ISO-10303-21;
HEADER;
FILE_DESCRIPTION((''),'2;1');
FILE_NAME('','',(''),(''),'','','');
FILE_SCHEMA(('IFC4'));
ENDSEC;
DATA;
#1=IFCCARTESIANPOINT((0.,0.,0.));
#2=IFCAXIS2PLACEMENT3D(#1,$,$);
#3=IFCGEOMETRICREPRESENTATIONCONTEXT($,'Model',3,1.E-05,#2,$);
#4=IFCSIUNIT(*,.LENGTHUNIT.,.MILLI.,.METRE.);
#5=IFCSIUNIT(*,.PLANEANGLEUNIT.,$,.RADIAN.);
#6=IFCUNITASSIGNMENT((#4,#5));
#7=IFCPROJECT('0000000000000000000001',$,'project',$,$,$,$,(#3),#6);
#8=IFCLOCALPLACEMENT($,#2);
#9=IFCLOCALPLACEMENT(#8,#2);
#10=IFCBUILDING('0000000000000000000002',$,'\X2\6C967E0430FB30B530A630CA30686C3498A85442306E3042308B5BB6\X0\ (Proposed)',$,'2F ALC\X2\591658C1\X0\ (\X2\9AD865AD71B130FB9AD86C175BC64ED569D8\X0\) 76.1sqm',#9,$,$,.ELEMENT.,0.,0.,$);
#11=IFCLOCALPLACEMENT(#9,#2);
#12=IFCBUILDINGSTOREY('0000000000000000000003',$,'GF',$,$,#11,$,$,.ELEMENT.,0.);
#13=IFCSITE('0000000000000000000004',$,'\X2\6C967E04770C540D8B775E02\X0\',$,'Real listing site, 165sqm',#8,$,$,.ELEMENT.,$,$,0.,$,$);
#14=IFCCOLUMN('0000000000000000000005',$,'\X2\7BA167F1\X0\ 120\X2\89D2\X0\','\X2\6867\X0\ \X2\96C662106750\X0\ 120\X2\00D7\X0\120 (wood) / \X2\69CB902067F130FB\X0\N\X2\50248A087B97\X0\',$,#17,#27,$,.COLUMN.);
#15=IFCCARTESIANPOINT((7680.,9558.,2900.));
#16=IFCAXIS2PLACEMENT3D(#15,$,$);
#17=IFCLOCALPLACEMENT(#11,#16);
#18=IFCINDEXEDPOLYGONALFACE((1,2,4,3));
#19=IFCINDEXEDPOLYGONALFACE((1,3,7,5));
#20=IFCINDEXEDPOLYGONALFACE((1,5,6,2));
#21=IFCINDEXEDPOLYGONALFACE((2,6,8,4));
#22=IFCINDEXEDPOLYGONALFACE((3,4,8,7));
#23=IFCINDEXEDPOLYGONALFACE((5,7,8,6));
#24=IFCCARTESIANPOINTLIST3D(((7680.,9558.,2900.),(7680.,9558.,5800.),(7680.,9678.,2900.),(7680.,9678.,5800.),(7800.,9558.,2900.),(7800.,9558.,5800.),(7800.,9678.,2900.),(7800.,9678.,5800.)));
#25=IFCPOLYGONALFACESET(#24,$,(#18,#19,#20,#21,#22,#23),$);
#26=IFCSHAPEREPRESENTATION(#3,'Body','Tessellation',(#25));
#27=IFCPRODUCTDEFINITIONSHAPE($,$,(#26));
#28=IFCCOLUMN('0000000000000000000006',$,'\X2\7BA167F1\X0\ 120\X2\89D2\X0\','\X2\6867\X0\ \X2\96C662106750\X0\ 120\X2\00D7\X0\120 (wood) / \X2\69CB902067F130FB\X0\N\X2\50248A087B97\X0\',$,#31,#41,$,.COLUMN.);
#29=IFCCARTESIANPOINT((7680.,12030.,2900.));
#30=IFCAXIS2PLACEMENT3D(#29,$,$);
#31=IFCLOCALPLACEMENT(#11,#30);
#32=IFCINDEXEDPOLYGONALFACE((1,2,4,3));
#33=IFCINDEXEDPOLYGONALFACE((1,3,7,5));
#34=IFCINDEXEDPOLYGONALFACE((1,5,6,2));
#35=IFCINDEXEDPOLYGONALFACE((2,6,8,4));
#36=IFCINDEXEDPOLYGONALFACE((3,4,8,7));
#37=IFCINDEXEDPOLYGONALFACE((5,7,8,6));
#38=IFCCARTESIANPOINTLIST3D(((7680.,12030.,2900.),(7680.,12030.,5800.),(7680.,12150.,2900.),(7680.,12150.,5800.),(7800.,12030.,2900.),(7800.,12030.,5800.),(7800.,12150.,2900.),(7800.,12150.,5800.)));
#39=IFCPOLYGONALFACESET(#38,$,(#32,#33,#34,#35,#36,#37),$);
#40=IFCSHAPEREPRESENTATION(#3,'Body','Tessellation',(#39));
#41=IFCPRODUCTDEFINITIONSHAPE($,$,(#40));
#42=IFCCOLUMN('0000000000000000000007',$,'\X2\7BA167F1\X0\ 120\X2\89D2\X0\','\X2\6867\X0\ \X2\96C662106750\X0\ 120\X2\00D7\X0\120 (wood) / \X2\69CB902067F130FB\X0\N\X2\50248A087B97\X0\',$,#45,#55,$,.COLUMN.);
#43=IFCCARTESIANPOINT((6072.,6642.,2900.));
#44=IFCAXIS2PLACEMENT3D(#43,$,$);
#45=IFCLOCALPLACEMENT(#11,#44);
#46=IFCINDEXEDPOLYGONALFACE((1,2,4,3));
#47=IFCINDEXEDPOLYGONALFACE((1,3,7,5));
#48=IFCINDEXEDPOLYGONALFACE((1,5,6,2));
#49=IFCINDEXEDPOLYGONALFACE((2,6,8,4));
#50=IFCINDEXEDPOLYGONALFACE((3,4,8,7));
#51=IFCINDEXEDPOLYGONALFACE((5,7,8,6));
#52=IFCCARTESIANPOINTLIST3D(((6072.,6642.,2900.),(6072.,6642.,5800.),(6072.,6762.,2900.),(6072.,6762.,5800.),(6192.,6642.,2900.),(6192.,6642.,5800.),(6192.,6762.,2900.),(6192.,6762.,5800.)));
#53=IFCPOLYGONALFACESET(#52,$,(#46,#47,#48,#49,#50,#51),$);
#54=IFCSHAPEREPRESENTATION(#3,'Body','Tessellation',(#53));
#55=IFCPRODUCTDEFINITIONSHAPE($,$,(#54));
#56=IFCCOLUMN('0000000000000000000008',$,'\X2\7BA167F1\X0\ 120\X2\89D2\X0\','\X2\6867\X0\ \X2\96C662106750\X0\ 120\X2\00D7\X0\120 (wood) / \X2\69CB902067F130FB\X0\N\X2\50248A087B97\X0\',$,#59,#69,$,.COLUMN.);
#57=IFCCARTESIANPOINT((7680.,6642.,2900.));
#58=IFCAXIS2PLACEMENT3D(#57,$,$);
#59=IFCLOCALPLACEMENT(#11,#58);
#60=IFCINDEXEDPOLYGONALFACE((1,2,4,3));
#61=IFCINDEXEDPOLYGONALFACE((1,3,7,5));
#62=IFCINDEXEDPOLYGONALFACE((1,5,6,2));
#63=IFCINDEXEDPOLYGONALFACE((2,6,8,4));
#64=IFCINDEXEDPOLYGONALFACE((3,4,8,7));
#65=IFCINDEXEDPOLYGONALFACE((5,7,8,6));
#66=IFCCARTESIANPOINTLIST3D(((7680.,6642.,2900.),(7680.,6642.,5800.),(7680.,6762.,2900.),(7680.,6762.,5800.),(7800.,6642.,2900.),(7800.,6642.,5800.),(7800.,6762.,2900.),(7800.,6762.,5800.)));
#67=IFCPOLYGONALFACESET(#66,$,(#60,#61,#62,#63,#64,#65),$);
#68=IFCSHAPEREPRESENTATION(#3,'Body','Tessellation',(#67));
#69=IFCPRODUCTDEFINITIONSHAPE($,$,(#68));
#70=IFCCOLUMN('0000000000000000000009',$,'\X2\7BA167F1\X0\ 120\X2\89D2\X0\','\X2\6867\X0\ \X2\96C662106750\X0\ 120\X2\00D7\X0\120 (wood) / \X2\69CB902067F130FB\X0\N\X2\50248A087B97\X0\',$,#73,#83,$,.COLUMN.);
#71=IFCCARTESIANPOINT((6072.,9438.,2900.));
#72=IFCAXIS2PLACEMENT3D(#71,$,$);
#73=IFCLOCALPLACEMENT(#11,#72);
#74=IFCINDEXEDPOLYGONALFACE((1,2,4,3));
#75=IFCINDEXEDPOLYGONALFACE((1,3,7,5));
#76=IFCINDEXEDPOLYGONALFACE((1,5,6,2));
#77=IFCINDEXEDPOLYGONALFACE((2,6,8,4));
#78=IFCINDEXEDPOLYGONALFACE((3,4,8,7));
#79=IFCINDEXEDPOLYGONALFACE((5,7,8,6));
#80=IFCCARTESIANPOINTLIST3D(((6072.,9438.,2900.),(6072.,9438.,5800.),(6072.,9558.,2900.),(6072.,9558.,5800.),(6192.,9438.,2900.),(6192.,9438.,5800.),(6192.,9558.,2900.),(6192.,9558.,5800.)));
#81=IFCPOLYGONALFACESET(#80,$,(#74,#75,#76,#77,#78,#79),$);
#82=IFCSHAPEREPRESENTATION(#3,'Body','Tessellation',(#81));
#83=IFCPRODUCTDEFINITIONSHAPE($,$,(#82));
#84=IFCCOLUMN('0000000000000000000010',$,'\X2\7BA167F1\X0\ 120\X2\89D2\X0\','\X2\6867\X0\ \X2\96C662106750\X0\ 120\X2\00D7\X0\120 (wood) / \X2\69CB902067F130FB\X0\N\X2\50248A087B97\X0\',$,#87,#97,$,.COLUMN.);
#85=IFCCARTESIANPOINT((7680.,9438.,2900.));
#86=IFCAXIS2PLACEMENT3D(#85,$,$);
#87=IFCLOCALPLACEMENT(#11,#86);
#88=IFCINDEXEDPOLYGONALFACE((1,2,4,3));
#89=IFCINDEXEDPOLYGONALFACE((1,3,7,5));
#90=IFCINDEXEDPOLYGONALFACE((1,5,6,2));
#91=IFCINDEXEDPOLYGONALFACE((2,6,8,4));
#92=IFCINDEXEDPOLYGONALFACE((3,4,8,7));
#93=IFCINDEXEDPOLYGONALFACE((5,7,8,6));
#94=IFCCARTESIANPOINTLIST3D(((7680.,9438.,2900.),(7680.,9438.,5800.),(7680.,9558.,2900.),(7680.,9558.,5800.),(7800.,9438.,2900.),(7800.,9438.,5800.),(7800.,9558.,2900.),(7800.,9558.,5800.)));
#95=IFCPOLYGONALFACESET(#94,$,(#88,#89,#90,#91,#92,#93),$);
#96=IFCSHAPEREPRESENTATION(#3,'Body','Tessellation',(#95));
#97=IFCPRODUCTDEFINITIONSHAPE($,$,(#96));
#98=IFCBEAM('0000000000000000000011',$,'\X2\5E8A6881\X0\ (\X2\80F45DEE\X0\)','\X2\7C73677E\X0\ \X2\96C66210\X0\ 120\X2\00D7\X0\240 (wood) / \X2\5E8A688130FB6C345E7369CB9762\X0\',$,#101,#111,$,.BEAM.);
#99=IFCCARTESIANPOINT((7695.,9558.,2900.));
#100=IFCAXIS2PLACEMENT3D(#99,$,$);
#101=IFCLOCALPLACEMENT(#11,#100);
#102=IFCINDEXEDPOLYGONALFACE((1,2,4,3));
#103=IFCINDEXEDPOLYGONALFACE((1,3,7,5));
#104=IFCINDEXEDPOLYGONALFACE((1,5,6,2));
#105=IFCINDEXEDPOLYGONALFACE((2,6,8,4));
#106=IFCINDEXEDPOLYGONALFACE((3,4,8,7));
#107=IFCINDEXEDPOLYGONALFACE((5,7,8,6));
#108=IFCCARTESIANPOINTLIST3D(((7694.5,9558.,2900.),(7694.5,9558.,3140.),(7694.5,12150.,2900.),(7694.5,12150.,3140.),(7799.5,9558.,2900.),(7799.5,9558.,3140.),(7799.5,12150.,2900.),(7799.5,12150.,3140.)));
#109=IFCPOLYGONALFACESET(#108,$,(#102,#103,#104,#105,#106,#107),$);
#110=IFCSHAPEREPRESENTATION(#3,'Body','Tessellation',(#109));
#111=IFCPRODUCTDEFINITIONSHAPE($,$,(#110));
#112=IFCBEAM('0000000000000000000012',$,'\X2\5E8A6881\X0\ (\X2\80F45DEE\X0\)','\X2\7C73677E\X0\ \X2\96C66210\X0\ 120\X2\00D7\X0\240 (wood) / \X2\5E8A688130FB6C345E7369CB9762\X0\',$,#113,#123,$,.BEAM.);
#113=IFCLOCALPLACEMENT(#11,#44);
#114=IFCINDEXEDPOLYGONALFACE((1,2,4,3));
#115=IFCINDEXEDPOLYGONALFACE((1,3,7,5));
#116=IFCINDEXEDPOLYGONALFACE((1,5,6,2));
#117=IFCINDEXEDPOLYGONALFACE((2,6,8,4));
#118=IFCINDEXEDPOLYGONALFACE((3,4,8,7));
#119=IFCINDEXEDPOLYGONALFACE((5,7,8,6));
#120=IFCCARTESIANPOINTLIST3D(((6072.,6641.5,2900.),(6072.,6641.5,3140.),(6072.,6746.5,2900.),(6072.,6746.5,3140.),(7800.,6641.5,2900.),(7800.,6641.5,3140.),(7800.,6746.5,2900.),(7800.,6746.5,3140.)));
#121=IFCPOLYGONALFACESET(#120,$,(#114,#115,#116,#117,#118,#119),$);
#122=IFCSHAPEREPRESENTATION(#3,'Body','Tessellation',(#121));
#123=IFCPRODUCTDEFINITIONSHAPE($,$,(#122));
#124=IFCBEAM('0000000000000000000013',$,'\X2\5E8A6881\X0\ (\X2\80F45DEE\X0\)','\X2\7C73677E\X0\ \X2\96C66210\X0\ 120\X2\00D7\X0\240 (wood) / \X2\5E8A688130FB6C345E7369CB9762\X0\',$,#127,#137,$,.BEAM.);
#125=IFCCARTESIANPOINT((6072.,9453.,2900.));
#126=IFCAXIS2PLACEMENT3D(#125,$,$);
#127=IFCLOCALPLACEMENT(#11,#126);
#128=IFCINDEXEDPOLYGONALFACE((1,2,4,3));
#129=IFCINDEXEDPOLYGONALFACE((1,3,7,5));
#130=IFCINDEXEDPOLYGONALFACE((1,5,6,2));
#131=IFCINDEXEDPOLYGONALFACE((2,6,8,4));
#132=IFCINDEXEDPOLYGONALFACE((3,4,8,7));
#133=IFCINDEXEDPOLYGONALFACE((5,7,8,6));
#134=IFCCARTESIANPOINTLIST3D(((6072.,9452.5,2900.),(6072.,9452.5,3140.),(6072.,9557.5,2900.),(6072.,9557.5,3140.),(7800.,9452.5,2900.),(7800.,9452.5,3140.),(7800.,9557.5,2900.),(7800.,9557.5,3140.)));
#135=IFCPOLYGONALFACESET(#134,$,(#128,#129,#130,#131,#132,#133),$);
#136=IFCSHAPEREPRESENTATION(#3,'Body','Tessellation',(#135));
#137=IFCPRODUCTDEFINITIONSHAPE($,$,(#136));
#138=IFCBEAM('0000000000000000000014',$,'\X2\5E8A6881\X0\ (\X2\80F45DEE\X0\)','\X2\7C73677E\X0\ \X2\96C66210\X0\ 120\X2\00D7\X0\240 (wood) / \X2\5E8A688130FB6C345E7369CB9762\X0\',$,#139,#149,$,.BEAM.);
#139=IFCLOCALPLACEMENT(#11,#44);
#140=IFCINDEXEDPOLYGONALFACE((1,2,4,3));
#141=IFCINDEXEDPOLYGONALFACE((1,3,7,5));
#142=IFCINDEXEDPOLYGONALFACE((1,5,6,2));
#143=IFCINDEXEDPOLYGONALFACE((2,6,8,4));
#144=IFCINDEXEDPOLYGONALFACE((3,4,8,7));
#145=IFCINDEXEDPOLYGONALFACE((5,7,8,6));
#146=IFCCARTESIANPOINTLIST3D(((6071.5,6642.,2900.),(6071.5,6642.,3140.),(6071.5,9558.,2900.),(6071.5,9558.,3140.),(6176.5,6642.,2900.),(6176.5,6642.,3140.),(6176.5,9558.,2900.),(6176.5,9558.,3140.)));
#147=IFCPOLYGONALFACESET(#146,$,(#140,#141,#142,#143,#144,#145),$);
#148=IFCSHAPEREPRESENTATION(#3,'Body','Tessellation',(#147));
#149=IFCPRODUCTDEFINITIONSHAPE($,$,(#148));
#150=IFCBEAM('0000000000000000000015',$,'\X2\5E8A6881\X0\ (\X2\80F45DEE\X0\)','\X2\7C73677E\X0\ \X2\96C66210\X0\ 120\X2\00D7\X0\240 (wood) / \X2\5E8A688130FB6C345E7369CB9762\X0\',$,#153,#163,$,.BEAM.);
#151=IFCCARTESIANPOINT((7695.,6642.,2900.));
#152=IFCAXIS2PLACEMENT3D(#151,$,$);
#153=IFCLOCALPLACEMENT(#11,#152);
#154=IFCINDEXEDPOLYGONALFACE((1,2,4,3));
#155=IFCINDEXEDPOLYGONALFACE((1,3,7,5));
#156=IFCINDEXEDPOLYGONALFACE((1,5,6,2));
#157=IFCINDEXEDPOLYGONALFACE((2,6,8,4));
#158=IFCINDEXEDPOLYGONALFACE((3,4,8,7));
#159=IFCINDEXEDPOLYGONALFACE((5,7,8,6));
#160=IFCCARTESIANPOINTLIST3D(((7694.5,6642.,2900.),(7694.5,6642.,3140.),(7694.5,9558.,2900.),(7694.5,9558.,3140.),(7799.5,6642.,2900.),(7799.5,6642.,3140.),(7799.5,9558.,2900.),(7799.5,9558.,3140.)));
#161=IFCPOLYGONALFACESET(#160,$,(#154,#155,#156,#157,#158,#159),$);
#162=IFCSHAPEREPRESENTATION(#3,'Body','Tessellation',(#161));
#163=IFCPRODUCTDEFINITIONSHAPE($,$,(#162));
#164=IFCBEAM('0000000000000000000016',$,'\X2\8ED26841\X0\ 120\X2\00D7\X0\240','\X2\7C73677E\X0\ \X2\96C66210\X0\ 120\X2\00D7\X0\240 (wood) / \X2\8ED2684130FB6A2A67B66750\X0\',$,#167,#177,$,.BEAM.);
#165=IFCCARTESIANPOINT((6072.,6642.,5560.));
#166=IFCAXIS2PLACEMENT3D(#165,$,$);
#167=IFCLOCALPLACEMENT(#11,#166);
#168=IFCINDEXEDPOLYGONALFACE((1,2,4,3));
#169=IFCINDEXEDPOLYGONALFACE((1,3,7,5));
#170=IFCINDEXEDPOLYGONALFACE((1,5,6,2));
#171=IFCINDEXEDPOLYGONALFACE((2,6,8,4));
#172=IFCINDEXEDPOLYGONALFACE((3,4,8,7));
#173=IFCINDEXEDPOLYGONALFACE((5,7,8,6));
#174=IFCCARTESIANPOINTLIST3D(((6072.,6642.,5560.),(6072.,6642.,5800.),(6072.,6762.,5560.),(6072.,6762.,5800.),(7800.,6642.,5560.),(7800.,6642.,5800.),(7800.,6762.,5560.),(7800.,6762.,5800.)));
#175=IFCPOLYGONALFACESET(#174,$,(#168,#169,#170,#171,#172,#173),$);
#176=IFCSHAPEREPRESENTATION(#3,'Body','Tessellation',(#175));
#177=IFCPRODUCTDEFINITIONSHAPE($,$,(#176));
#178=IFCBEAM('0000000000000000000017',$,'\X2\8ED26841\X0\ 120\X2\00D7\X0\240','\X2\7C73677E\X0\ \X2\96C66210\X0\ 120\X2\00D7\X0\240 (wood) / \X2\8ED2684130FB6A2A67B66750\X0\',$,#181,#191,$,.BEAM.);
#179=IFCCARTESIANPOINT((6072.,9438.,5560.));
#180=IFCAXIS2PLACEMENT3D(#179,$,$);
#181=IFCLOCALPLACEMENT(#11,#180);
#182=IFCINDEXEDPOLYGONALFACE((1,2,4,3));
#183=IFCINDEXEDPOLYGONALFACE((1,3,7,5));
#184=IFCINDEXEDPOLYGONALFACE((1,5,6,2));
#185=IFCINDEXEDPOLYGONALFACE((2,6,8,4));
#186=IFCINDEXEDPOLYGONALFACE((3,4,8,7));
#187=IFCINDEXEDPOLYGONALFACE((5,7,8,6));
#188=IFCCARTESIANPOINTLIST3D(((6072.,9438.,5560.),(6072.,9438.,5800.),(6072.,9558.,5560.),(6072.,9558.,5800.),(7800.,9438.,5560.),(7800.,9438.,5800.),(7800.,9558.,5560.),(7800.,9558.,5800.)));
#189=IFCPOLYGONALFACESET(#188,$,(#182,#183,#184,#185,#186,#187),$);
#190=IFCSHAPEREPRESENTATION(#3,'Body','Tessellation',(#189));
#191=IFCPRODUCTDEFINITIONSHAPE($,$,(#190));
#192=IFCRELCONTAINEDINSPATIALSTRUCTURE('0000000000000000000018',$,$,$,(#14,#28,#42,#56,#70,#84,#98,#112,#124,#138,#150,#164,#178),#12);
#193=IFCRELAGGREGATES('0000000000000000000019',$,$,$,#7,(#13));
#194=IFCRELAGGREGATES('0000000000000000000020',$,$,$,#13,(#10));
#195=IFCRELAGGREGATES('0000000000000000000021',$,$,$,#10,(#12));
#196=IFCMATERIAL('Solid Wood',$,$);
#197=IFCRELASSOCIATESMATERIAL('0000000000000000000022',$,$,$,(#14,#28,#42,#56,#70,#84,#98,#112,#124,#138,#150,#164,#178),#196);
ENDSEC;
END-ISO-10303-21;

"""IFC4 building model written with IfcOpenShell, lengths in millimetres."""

from ifc_helpers import new_model, si_unit, frame, frame_2d, origin, place, context, project, spatial, rectangle, extrude, material, element, save


model = new_model("IFC4")

# Units and contexts
model_context = context("Model", 3, precision=1e-05, world=origin())
ifc_project = project(units=[si_unit("LENGTHUNIT", "METRE", prefix="MILLI"), si_unit("PLANEANGLEUNIT", "RADIAN")], contexts=[model_context])

# Site, building, storey
site_placement = place(None, origin())
site = spatial("IfcSite", under=ifc_project, at=site_placement, Name="沖縄県名護市", ObjectType="Real listing site, 165sqm", CompositionType="ELEMENT", RefElevation=0.0)
building_placement = place(site_placement, origin())
building = spatial("IfcBuilding", under=site, at=building_placement, Name="沖縄・サウナと水風呂のある家 (Proposed)", ObjectType="2F ALC外壁 (高断熱・高気密仕様) 76.1sqm", CompositionType="ELEMENT", ElevationOfRefHeight=0.0, ElevationOfTerrain=0.0)
storey_placement = place(building_placement, origin())
storey = spatial("IfcBuildingStorey", under=building, at=storey_placement, Name="GF", CompositionType="ELEMENT", Elevation=0.0)

# Columns
ifc_material_1 = material(Name="Solid Wood")
column_1_placement = place(storey_placement, frame((7680.0, 9558.0, 2900.0)))
element("IfcColumn", 1, at=column_1_placement, inside=storey, material=ifc_material_1, Name="管柱 120角", Description="桧 集成材 120×120 (wood) / 構造柱・N値計算", PredefinedType="COLUMN", context=model_context, shape_type="SweptSolid", body=[
    extrude(rectangle(XDim=120.0, YDim=120.0, at=frame_2d((60.0, 60.0))), frame((7680.0, 9558.0, 2900.0)), (0.0, 0.0, 1.0), 2900.0),
])
column_2_placement = place(storey_placement, frame((7680.0, 12030.0, 2900.0)))
element("IfcColumn", 2, at=column_2_placement, inside=storey, material=ifc_material_1, Name="管柱 120角", Description="桧 集成材 120×120 (wood) / 構造柱・N値計算", PredefinedType="COLUMN", context=model_context, shape_type="SweptSolid", body=[
    extrude(rectangle(XDim=120.0, YDim=120.0, at=frame_2d((60.0, 60.0))), frame((7680.0, 12030.0, 2900.0)), (0.0, 0.0, 1.0), 2900.0),
])
column_3_placement = place(storey_placement, frame((6072.0, 6642.0, 2900.0)))
element("IfcColumn", 3, at=column_3_placement, inside=storey, material=ifc_material_1, Name="管柱 120角", Description="桧 集成材 120×120 (wood) / 構造柱・N値計算", PredefinedType="COLUMN", context=model_context, shape_type="SweptSolid", body=[
    extrude(rectangle(XDim=120.0, YDim=120.0, at=frame_2d((60.0, 60.0))), frame((6072.0, 6642.0, 2900.0)), (0.0, 0.0, 1.0), 2900.0),
])
column_4_placement = place(storey_placement, frame((7680.0, 6642.0, 2900.0)))
element("IfcColumn", 4, at=column_4_placement, inside=storey, material=ifc_material_1, Name="管柱 120角", Description="桧 集成材 120×120 (wood) / 構造柱・N値計算", PredefinedType="COLUMN", context=model_context, shape_type="SweptSolid", body=[
    extrude(rectangle(XDim=120.0, YDim=120.0, at=frame_2d((60.0, 60.0))), frame((7680.0, 6642.0, 2900.0)), (0.0, 0.0, 1.0), 2900.0),
])
column_5_placement = place(storey_placement, frame((6072.0, 9438.0, 2900.0)))
element("IfcColumn", 5, at=column_5_placement, inside=storey, material=ifc_material_1, Name="管柱 120角", Description="桧 集成材 120×120 (wood) / 構造柱・N値計算", PredefinedType="COLUMN", context=model_context, shape_type="SweptSolid", body=[
    extrude(rectangle(XDim=120.0, YDim=120.0, at=frame_2d((60.0, 60.0))), frame((6072.0, 9438.0, 2900.0)), (0.0, 0.0, 1.0), 2900.0),
])
column_6_placement = place(storey_placement, frame((7680.0, 9438.0, 2900.0)))
element("IfcColumn", 6, at=column_6_placement, inside=storey, material=ifc_material_1, Name="管柱 120角", Description="桧 集成材 120×120 (wood) / 構造柱・N値計算", PredefinedType="COLUMN", context=model_context, shape_type="SweptSolid", body=[
    extrude(rectangle(XDim=120.0, YDim=120.0, at=frame_2d((60.0, 60.0))), frame((7680.0, 9438.0, 2900.0)), (0.0, 0.0, 1.0), 2900.0),
])

# Beams
beam_1_placement = place(storey_placement, frame((7695.0, 9558.0, 2900.0)))
element("IfcBeam", 7, at=beam_1_placement, inside=storey, material=ifc_material_1, Name="床梁 (胴差)", Description="米松 集成 120×240 (wood) / 床梁・水平構面", PredefinedType="BEAM", context=model_context, shape_type="SweptSolid", body=[
    extrude(rectangle(XDim=105.0, YDim=2592.0, at=frame_2d((52.0, 1296.0))), frame((7695.0, 9558.0, 2900.0)), (0.0, 0.0, 1.0), 240.0),
])
beam_2_placement = place(storey_placement, frame((6072.0, 6642.0, 2900.0)))
element("IfcBeam", 8, at=beam_2_placement, inside=storey, material=ifc_material_1, Name="床梁 (胴差)", Description="米松 集成 120×240 (wood) / 床梁・水平構面", PredefinedType="BEAM", context=model_context, shape_type="SweptSolid", body=[
    extrude(rectangle(XDim=1728.0, YDim=105.0, at=frame_2d((864.0, 52.0))), frame((6072.0, 6642.0, 2900.0)), (0.0, 0.0, 1.0), 240.0),
])
beam_3_placement = place(storey_placement, frame((6072.0, 9453.0, 2900.0)))
element("IfcBeam", 9, at=beam_3_placement, inside=storey, material=ifc_material_1, Name="床梁 (胴差)", Description="米松 集成 120×240 (wood) / 床梁・水平構面", PredefinedType="BEAM", context=model_context, shape_type="SweptSolid", body=[
    extrude(rectangle(XDim=1728.0, YDim=105.0, at=frame_2d((864.0, 52.0))), frame((6072.0, 9453.0, 2900.0)), (0.0, 0.0, 1.0), 240.0),
])
beam_4_placement = place(storey_placement, frame((6072.0, 6642.0, 2900.0)))
element("IfcBeam", 10, at=beam_4_placement, inside=storey, material=ifc_material_1, Name="床梁 (胴差)", Description="米松 集成 120×240 (wood) / 床梁・水平構面", PredefinedType="BEAM", context=model_context, shape_type="SweptSolid", body=[
    extrude(rectangle(XDim=105.0, YDim=2916.0, at=frame_2d((52.0, 1458.0))), frame((6072.0, 6642.0, 2900.0)), (0.0, 0.0, 1.0), 240.0),
])
beam_5_placement = place(storey_placement, frame((7695.0, 6642.0, 2900.0)))
element("IfcBeam", 11, at=beam_5_placement, inside=storey, material=ifc_material_1, Name="床梁 (胴差)", Description="米松 集成 120×240 (wood) / 床梁・水平構面", PredefinedType="BEAM", context=model_context, shape_type="SweptSolid", body=[
    extrude(rectangle(XDim=105.0, YDim=2916.0, at=frame_2d((52.0, 1458.0))), frame((7695.0, 6642.0, 2900.0)), (0.0, 0.0, 1.0), 240.0),
])
beam_6_placement = place(storey_placement, frame((6072.0, 6642.0, 5560.0)))
element("IfcBeam", 12, at=beam_6_placement, inside=storey, material=ifc_material_1, Name="軒桁 120×240", Description="米松 集成 120×240 (wood) / 軒桁・横架材", PredefinedType="BEAM", context=model_context, shape_type="SweptSolid", body=[
    extrude(rectangle(XDim=1728.0, YDim=120.0, at=frame_2d((864.0, 60.0))), frame((6072.0, 6642.0, 5560.0)), (0.0, 0.0, 1.0), 240.0),
])
beam_7_placement = place(storey_placement, frame((6072.0, 9438.0, 5560.0)))
element("IfcBeam", 13, at=beam_7_placement, inside=storey, material=ifc_material_1, Name="軒桁 120×240", Description="米松 集成 120×240 (wood) / 軒桁・横架材", PredefinedType="BEAM", context=model_context, shape_type="SweptSolid", body=[
    extrude(rectangle(XDim=1728.0, YDim=120.0, at=frame_2d((864.0, 60.0))), frame((6072.0, 9438.0, 5560.0)), (0.0, 0.0, 1.0), 240.0),
])

save(model, "model.ifc")
